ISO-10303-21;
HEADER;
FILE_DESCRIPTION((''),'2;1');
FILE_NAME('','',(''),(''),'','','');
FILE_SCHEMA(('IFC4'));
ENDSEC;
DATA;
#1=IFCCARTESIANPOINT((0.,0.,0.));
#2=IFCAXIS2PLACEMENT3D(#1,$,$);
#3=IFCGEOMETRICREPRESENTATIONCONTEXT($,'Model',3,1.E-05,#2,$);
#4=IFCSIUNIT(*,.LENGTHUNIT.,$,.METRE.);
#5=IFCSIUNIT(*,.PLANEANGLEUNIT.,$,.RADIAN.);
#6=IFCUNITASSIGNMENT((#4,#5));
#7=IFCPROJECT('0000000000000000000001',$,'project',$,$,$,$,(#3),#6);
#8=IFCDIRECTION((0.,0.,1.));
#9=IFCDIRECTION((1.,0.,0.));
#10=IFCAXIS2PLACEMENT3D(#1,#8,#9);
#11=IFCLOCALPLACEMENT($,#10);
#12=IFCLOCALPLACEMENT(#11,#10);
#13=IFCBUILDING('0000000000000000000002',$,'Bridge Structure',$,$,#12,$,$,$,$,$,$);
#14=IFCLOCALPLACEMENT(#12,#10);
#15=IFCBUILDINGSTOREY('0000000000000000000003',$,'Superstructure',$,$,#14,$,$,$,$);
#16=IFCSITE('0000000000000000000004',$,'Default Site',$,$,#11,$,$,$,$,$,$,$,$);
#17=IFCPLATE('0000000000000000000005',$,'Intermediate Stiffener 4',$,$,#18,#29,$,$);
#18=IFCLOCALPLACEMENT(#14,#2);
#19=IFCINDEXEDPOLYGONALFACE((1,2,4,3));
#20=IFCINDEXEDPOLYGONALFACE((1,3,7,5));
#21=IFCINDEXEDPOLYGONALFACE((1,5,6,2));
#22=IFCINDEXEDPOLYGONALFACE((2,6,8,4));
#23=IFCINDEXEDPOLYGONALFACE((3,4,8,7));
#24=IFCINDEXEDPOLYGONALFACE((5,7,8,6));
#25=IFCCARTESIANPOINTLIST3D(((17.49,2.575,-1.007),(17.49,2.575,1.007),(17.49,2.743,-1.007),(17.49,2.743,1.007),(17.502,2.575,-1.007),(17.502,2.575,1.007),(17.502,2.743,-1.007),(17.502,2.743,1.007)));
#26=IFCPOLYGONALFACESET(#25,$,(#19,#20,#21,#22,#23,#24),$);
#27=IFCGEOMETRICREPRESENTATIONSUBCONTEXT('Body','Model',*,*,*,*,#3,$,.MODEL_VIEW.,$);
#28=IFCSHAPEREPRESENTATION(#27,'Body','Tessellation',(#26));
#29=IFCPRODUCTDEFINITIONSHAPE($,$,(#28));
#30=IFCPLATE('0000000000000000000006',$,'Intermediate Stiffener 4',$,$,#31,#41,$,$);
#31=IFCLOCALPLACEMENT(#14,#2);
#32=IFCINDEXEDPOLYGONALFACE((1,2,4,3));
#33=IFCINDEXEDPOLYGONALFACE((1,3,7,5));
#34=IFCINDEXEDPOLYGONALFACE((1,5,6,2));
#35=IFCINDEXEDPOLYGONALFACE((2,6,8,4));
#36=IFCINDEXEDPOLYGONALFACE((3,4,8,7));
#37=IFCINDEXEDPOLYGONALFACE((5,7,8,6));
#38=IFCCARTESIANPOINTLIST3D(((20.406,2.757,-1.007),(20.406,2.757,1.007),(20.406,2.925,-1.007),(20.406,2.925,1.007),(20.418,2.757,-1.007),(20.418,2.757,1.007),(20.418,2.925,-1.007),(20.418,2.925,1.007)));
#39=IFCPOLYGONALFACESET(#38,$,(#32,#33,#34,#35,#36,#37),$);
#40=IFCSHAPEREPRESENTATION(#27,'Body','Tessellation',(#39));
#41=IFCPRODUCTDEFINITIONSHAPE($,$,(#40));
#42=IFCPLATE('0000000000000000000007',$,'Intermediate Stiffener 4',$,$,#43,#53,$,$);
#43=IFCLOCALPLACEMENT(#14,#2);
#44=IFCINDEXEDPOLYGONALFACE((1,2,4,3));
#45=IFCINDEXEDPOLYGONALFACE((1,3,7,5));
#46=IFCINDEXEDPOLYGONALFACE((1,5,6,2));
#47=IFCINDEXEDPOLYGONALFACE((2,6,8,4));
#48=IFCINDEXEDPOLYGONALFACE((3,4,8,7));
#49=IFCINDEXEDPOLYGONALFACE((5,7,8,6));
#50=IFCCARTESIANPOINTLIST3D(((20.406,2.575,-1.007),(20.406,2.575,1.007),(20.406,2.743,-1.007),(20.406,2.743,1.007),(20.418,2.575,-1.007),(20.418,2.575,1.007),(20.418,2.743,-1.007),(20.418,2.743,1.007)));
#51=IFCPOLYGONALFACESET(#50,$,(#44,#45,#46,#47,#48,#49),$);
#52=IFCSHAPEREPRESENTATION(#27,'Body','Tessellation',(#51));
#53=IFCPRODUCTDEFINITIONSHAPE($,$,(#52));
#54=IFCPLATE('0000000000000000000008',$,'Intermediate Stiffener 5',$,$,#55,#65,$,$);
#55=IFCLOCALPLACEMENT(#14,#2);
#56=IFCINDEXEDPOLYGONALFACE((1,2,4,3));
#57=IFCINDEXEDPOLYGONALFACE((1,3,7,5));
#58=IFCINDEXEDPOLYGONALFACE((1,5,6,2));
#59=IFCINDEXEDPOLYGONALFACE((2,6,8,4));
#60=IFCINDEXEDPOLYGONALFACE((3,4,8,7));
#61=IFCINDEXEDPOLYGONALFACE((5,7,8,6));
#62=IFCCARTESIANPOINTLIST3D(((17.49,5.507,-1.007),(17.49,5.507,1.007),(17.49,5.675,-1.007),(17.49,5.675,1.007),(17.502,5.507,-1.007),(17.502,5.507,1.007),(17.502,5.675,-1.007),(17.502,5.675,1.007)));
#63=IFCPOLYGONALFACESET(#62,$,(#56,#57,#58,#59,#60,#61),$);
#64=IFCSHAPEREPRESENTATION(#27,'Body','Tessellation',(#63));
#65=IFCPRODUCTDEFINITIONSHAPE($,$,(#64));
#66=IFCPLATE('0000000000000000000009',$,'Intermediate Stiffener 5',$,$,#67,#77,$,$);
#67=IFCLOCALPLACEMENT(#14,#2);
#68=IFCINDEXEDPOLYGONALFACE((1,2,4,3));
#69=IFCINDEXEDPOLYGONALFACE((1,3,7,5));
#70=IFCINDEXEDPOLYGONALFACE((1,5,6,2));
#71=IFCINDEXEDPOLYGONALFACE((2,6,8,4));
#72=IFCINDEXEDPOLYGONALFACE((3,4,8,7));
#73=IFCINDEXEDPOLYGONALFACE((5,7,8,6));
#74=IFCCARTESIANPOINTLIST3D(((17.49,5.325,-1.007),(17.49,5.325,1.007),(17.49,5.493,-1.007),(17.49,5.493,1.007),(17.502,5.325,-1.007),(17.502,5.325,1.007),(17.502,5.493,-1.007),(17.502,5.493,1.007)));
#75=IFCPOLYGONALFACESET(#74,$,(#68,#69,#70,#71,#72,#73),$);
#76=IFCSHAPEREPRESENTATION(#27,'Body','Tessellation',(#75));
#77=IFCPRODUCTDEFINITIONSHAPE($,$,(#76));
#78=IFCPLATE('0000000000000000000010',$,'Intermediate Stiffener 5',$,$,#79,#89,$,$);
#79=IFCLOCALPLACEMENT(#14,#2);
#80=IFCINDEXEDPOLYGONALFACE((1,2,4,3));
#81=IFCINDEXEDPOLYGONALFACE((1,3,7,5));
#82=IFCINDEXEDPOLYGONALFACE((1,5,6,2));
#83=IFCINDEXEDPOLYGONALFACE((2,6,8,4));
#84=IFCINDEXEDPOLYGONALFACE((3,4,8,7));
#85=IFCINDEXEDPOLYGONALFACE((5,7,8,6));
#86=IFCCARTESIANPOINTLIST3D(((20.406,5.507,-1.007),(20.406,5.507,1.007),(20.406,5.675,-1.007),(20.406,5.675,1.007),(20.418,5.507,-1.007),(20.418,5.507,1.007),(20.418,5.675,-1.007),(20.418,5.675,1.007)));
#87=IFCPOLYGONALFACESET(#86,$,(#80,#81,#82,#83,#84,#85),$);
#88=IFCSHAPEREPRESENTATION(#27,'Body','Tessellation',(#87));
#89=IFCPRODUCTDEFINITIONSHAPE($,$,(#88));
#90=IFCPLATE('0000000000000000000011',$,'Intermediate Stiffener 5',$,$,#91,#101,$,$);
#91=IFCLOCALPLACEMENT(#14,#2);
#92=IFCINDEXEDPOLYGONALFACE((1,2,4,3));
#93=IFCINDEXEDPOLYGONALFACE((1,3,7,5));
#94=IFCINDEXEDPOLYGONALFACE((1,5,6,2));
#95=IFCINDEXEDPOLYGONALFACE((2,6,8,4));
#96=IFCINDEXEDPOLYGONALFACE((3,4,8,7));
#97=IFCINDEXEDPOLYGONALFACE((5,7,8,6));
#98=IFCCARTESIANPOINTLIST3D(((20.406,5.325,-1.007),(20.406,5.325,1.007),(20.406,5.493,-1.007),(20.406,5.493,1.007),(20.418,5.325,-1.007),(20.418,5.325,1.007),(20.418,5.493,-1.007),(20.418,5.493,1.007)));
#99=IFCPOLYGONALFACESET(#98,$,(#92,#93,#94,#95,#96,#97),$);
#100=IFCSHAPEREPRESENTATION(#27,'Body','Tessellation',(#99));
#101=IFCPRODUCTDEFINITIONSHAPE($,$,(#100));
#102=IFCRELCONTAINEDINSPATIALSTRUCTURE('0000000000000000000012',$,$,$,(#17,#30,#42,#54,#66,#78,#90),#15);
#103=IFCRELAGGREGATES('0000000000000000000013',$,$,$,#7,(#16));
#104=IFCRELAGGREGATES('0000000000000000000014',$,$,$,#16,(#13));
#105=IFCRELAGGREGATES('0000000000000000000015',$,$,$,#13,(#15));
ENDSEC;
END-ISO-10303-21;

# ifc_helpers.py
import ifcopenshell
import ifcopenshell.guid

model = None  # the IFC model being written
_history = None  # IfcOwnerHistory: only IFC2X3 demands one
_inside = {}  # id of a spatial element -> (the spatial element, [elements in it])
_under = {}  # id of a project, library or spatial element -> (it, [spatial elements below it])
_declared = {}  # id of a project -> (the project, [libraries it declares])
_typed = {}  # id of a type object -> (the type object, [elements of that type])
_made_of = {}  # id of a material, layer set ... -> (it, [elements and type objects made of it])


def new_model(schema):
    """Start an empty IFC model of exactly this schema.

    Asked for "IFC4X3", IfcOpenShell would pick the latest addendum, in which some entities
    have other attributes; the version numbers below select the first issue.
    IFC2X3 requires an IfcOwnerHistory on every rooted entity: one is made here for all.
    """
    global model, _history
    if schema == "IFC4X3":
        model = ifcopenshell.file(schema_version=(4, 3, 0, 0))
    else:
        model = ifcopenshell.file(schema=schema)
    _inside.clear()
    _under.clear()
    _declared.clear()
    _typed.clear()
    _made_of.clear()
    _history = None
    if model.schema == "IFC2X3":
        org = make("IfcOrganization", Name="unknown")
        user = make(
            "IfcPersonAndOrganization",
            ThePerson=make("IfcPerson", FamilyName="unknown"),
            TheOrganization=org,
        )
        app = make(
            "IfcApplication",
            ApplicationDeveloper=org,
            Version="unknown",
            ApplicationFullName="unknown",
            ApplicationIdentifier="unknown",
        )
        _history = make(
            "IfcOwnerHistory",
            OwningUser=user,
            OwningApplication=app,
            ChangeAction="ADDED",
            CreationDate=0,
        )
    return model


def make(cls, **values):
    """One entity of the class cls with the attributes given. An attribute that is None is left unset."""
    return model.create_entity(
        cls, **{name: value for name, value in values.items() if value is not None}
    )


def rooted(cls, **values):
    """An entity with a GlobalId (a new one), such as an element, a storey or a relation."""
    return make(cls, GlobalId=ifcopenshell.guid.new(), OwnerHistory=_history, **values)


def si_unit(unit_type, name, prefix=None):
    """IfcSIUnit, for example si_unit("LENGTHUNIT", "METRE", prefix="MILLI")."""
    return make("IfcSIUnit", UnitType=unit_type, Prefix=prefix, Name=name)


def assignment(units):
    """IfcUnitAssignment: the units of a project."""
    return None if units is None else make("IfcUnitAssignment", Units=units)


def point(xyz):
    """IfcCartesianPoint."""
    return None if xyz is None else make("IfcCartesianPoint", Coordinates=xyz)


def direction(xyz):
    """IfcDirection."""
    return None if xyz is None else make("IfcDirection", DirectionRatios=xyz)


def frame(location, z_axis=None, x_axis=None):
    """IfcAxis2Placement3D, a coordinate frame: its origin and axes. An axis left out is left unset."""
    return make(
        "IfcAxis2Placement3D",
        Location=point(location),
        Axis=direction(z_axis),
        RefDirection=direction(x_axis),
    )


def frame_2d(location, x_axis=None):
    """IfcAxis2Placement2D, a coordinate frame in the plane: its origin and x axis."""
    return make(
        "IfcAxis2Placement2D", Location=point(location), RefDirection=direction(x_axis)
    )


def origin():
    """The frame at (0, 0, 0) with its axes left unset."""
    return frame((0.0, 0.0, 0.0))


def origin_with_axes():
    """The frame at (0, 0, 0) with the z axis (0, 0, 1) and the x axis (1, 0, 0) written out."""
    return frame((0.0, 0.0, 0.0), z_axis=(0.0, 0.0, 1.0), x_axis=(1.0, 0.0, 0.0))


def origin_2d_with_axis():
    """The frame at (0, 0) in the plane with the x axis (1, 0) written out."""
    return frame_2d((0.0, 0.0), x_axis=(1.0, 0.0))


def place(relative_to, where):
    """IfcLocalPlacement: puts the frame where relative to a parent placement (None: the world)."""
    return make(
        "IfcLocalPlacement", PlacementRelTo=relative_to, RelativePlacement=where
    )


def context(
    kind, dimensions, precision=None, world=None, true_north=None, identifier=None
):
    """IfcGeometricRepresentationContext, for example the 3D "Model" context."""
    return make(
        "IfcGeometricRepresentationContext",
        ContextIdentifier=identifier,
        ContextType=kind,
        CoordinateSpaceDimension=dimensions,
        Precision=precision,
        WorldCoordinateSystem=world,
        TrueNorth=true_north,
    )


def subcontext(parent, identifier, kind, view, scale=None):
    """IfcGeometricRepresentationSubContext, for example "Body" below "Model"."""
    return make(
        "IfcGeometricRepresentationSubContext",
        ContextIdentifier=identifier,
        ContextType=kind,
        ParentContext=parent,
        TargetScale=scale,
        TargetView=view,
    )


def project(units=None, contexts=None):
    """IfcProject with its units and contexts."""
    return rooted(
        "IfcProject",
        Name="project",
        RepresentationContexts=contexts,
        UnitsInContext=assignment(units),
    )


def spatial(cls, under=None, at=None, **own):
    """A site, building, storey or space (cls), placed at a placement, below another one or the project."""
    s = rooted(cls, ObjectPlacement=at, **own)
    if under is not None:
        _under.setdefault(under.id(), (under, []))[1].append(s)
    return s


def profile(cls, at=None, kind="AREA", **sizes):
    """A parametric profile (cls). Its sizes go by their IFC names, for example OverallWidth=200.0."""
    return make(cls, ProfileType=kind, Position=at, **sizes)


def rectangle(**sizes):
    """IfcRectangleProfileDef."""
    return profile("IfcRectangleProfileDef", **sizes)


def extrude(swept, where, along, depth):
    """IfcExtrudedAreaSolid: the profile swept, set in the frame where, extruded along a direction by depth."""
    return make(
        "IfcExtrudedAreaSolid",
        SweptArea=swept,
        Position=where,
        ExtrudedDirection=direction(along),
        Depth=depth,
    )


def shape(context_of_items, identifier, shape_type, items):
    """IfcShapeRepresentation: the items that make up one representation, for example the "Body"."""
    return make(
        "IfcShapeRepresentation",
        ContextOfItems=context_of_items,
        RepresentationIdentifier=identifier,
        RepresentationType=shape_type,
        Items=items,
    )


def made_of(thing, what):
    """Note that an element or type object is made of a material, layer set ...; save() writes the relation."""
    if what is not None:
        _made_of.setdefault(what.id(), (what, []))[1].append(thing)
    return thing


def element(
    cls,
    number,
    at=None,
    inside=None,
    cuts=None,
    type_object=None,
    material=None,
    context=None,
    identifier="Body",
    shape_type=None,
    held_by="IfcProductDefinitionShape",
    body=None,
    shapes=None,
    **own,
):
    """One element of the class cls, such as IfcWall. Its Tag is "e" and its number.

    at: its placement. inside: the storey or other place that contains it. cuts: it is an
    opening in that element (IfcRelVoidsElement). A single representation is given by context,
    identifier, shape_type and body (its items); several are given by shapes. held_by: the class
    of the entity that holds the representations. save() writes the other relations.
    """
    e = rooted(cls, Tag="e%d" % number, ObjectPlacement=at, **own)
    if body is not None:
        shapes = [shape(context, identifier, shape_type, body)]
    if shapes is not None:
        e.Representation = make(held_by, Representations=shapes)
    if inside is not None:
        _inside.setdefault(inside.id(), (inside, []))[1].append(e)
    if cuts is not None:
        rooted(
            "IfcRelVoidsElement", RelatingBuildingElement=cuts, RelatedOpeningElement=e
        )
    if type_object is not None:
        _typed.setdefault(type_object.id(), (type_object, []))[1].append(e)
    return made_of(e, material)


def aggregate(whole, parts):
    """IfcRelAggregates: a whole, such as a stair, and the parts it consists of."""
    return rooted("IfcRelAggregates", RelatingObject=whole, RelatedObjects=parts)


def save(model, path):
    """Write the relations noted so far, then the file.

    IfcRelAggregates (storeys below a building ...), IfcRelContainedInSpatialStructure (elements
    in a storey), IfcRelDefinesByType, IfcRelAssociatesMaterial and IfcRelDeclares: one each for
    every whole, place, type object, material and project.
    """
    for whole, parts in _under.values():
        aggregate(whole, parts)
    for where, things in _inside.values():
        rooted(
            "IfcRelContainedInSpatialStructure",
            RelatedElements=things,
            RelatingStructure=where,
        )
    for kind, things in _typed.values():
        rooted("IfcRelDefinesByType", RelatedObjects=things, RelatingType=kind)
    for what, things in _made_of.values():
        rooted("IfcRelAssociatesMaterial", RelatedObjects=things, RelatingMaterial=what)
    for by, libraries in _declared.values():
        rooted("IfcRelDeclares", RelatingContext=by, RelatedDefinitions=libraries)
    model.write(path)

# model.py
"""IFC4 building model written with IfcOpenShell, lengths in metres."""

from ifc_helpers import new_model, si_unit, frame, origin, origin_with_axes, origin_2d_with_axis, place, context, subcontext, project, spatial, rectangle, extrude, element, save


model = new_model("IFC4")

# Units and contexts
model_context = context("Model", 3, precision=1e-05, world=origin())
body_context = subcontext(model_context, "Body", "Model", "MODEL_VIEW")
ifc_project = project(units=[si_unit("LENGTHUNIT", "METRE"), si_unit("PLANEANGLEUNIT", "RADIAN")], contexts=[model_context])

# Site, building, storey
site_placement = place(None, origin_with_axes())
site = spatial("IfcSite", under=ifc_project, at=site_placement, Name="Default Site")
building_placement = place(site_placement, origin_with_axes())
building = spatial("IfcBuilding", under=site, at=building_placement, Name="Bridge Structure")
storey_placement = place(building_placement, origin_with_axes())
storey = spatial("IfcBuildingStorey", under=building, at=storey_placement, Name="Superstructure")

# Plates
for number, where, z_axis, x_axis, name in (
    (1, (17.496, 2.659, -1.007), (0.0, 0.0, 1.0), (1.0, 0.0, 0.0), "Intermediate Stiffener 4"),
    (2, (20.412, 2.841, -1.007), (0.0, 0.0, 1.0), (1.0, 0.0, 0.0), "Intermediate Stiffener 4"),
    (3, (20.412, 2.659, -1.007), (0.0, 0.0, 1.0), (1.0, 0.0, 0.0), "Intermediate Stiffener 4"),
    (4, (17.496, 5.591, -1.007), (0.0, 0.0, 1.0), (1.0, 0.0, 0.0), "Intermediate Stiffener 5"),
    (5, (17.496, 5.409, -1.007), (0.0, 0.0, 1.0), (1.0, 0.0, 0.0), "Intermediate Stiffener 5"),
    (6, (20.412, 5.591, -1.007), (0.0, 0.0, 1.0), (1.0, 0.0, 0.0), "Intermediate Stiffener 5"),
    (7, (20.412, 5.409, -1.007), (0.0, 0.0, 1.0), (1.0, 0.0, 0.0), "Intermediate Stiffener 5"),
):
    element("IfcPlate", number, at=place(storey_placement, frame(where, z_axis=z_axis, x_axis=x_axis)), inside=storey, Name=name, context=body_context, shape_type="SweptSolid", body=[
        extrude(rectangle(XDim=0.012, YDim=0.168, at=origin_2d_with_axis()), origin_with_axes(), (0.0, 0.0, 1.0), 2.014),
    ])

save(model, "model.ifc")
